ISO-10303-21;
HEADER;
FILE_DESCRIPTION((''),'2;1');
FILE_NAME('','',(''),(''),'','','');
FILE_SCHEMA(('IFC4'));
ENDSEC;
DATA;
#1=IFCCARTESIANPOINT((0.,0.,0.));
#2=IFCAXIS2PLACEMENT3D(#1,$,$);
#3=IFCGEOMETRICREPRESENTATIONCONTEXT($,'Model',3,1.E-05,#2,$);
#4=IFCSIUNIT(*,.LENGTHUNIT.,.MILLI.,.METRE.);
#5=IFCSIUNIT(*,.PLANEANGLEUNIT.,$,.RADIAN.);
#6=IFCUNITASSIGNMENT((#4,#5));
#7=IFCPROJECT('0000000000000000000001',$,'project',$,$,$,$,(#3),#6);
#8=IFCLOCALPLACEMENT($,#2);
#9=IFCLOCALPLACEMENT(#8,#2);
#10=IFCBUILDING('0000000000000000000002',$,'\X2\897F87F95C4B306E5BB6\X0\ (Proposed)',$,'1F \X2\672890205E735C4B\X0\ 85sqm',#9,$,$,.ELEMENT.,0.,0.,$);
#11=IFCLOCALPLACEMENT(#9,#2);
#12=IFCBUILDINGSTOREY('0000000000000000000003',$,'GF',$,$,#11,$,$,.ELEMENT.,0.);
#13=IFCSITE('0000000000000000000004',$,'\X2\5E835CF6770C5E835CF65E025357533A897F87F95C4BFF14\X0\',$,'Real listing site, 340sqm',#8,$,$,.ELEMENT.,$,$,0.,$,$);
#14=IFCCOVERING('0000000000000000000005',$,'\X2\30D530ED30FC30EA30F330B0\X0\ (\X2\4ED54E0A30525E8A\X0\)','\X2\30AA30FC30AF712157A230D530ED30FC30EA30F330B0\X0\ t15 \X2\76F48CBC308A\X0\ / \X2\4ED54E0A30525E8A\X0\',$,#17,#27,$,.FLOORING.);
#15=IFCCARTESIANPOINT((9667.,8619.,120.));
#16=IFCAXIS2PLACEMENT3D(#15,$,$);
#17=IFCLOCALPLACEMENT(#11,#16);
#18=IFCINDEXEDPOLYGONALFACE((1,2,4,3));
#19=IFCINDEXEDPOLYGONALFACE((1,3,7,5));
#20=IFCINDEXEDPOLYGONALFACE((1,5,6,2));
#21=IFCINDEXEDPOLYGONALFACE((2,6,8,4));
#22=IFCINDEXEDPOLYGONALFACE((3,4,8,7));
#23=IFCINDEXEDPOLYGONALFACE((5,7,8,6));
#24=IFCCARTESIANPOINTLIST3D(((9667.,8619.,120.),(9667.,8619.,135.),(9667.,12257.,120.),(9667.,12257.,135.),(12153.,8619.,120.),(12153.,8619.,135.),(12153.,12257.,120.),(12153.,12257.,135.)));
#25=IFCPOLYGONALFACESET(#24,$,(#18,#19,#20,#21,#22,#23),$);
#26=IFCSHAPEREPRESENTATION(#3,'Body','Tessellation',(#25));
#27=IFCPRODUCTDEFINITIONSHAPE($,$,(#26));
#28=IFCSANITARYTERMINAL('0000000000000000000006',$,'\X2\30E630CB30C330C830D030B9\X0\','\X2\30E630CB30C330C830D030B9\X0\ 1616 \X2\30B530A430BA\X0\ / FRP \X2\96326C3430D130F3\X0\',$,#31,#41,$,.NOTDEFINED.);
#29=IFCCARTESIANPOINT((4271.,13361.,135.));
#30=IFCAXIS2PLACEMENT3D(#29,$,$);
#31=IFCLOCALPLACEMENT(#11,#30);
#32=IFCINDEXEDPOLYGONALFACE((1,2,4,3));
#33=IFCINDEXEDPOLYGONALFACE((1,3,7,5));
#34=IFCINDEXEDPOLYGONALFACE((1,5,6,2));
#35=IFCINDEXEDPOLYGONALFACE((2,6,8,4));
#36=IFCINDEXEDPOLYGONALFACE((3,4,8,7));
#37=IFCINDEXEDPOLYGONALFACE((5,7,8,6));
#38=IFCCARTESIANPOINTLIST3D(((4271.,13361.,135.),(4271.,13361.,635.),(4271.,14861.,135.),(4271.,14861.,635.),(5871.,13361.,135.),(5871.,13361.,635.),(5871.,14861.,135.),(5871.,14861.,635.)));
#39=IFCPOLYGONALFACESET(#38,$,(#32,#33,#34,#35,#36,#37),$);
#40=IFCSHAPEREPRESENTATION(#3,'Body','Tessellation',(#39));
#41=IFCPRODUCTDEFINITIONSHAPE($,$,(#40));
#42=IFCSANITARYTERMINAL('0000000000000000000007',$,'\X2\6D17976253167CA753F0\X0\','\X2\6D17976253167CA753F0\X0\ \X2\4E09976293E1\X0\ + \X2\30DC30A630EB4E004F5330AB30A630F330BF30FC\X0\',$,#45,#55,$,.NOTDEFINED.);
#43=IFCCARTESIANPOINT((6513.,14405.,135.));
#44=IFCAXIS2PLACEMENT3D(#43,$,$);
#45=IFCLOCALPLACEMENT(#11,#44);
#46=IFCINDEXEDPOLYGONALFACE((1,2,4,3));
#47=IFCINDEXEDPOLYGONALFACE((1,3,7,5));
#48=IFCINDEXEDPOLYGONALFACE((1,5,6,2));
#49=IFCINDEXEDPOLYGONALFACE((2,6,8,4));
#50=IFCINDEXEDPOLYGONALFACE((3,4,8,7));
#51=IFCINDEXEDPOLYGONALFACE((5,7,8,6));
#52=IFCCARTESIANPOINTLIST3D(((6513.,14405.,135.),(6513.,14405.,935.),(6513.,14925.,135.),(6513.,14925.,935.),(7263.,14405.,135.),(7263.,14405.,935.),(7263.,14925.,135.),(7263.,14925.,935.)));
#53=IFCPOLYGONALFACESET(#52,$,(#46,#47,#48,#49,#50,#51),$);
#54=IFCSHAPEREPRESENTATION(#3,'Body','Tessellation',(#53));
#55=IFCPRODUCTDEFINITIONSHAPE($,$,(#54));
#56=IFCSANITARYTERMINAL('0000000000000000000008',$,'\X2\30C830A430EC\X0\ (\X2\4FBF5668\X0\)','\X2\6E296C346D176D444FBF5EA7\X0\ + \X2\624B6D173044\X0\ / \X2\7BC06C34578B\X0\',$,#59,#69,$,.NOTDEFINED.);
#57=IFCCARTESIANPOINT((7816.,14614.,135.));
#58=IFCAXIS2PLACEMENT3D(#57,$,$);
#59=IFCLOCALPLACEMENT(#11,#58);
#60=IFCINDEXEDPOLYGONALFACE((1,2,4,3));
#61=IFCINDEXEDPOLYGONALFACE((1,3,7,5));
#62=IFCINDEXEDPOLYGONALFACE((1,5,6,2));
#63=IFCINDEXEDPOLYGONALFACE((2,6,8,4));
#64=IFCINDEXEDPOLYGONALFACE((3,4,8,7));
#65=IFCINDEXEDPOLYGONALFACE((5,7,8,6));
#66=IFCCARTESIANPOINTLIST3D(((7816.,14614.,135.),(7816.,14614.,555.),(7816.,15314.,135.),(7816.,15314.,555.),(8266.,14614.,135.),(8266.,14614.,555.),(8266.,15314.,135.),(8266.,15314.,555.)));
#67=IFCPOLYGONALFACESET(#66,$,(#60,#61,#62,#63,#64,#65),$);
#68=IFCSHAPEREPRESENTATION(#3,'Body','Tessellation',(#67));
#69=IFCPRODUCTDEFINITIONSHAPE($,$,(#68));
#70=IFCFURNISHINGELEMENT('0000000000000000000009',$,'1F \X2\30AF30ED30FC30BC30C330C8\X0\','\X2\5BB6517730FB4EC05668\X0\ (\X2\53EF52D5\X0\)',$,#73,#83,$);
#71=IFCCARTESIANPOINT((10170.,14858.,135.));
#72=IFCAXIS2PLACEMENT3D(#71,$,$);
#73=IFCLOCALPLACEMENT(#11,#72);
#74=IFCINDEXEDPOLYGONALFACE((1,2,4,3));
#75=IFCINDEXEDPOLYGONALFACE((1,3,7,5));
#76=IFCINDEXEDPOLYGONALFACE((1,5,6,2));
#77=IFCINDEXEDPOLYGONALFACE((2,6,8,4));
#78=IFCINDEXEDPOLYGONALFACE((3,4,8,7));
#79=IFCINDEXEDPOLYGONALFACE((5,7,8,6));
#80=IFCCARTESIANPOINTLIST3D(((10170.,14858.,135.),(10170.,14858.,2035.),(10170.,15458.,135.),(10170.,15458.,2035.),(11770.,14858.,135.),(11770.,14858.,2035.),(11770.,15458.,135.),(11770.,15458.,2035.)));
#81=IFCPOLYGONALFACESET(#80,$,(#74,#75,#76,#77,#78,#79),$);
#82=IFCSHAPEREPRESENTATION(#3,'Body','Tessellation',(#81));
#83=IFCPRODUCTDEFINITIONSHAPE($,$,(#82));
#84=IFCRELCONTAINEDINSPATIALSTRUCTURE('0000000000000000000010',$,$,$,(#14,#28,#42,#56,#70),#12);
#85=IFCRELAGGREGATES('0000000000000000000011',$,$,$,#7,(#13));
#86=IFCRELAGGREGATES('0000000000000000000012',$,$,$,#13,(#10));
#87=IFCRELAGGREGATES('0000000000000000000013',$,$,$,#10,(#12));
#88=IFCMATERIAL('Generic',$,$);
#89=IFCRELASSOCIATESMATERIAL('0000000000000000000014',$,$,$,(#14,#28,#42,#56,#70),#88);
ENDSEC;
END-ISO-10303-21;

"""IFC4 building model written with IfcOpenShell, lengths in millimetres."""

from ifc_helpers import new_model, si_unit, frame, frame_2d, origin, place, context, project, spatial, rectangle, extrude, material, element, save


model = new_model("IFC4")

# Units and contexts
model_context = context("Model", 3, precision=1e-05, world=origin())
ifc_project = project(units=[si_unit("LENGTHUNIT", "METRE", prefix="MILLI"), si_unit("PLANEANGLEUNIT", "RADIAN")], contexts=[model_context])

# Site, building, storey
site_placement = place(None, origin())
site = spatial("IfcSite", under=ifc_project, at=site_placement, Name="広島県広島市南区西蟹屋４", ObjectType="Real listing site, 340sqm", CompositionType="ELEMENT", RefElevation=0.0)
building_placement = place(site_placement, origin())
building = spatial("IfcBuilding", under=site, at=building_placement, Name="西蟹屋の家 (Proposed)", ObjectType="1F 木造平屋 85sqm", CompositionType="ELEMENT", ElevationOfRefHeight=0.0, ElevationOfTerrain=0.0)
storey_placement = place(building_placement, origin())
storey = spatial("IfcBuildingStorey", under=building, at=storey_placement, Name="GF", CompositionType="ELEMENT", Elevation=0.0)

# Covering
ifc_material_1 = material(Name="Generic")
covering_1_placement = place(storey_placement, frame((9667.0, 8619.0, 120.0)))
element("IfcCovering", 1, at=covering_1_placement, inside=storey, material=ifc_material_1, Name="フローリング (仕上げ床)", Description="オーク無垢フローリング t15 直貼り / 仕上げ床", PredefinedType="FLOORING", context=model_context, shape_type="SweptSolid", body=[
    extrude(rectangle(XDim=2486.0, YDim=3638.0, at=frame_2d((1243.0, 1819.0))), frame((9667.0, 8619.0, 120.0)), (0.0, 0.0, 1.0), 15.0),
])

# Sanitary terminals
sanitary_terminal_1_placement = place(storey_placement, frame((4271.0, 13361.0, 135.0)))
element("IfcSanitaryTerminal", 2, at=sanitary_terminal_1_placement, inside=storey, material=ifc_material_1, Name="ユニットバス", Description="ユニットバス 1616 サイズ / FRP 防水パン", PredefinedType="NOTDEFINED", context=model_context, shape_type="SweptSolid", body=[
    extrude(rectangle(XDim=1600.0, YDim=1500.0, at=frame_2d((800.0, 750.0))), frame((4271.0, 13361.0, 135.0)), (0.0, 0.0, 1.0), 500.0),
])
sanitary_terminal_2_placement = place(storey_placement, frame((6513.0, 14405.0, 135.0)))
element("IfcSanitaryTerminal", 3, at=sanitary_terminal_2_placement, inside=storey, material=ifc_material_1, Name="洗面化粧台", Description="洗面化粧台 三面鏡 + ボウル一体カウンター", PredefinedType="NOTDEFINED", context=model_context, shape_type="SweptSolid", body=[
    extrude(rectangle(XDim=750.0, YDim=520.0, at=frame_2d((375.0, 260.0))), frame((6513.0, 14405.0, 135.0)), (0.0, 0.0, 1.0), 800.0),
])
sanitary_terminal_3_placement = place(storey_placement, frame((7816.0, 14614.0, 135.0)))
element("IfcSanitaryTerminal", 4, at=sanitary_terminal_3_placement, inside=storey, material=ifc_material_1, Name="トイレ (便器)", Description="温水洗浄便座 + 手洗い / 節水型", PredefinedType="NOTDEFINED", context=model_context, shape_type="SweptSolid", body=[
    extrude(rectangle(XDim=450.0, YDim=700.0, at=frame_2d((225.0, 350.0))), frame((7816.0, 14614.0, 135.0)), (0.0, 0.0, 1.0), 420.0),
])

# Furnishing element
furnishing_placement = place(storey_placement, frame((10170.0, 14858.0, 135.0)))
element("IfcFurnishingElement", 5, at=furnishing_placement, inside=storey, material=ifc_material_1, Name="1F クローゼット", Description="家具・什器 (可動)", context=model_context, shape_type="SweptSolid", body=[
    extrude(rectangle(XDim=1600.0, YDim=600.0, at=frame_2d((800.0, 300.0))), frame((10170.0, 14858.0, 135.0)), (0.0, 0.0, 1.0), 1900.0),
])

save(model, "model.ifc")
